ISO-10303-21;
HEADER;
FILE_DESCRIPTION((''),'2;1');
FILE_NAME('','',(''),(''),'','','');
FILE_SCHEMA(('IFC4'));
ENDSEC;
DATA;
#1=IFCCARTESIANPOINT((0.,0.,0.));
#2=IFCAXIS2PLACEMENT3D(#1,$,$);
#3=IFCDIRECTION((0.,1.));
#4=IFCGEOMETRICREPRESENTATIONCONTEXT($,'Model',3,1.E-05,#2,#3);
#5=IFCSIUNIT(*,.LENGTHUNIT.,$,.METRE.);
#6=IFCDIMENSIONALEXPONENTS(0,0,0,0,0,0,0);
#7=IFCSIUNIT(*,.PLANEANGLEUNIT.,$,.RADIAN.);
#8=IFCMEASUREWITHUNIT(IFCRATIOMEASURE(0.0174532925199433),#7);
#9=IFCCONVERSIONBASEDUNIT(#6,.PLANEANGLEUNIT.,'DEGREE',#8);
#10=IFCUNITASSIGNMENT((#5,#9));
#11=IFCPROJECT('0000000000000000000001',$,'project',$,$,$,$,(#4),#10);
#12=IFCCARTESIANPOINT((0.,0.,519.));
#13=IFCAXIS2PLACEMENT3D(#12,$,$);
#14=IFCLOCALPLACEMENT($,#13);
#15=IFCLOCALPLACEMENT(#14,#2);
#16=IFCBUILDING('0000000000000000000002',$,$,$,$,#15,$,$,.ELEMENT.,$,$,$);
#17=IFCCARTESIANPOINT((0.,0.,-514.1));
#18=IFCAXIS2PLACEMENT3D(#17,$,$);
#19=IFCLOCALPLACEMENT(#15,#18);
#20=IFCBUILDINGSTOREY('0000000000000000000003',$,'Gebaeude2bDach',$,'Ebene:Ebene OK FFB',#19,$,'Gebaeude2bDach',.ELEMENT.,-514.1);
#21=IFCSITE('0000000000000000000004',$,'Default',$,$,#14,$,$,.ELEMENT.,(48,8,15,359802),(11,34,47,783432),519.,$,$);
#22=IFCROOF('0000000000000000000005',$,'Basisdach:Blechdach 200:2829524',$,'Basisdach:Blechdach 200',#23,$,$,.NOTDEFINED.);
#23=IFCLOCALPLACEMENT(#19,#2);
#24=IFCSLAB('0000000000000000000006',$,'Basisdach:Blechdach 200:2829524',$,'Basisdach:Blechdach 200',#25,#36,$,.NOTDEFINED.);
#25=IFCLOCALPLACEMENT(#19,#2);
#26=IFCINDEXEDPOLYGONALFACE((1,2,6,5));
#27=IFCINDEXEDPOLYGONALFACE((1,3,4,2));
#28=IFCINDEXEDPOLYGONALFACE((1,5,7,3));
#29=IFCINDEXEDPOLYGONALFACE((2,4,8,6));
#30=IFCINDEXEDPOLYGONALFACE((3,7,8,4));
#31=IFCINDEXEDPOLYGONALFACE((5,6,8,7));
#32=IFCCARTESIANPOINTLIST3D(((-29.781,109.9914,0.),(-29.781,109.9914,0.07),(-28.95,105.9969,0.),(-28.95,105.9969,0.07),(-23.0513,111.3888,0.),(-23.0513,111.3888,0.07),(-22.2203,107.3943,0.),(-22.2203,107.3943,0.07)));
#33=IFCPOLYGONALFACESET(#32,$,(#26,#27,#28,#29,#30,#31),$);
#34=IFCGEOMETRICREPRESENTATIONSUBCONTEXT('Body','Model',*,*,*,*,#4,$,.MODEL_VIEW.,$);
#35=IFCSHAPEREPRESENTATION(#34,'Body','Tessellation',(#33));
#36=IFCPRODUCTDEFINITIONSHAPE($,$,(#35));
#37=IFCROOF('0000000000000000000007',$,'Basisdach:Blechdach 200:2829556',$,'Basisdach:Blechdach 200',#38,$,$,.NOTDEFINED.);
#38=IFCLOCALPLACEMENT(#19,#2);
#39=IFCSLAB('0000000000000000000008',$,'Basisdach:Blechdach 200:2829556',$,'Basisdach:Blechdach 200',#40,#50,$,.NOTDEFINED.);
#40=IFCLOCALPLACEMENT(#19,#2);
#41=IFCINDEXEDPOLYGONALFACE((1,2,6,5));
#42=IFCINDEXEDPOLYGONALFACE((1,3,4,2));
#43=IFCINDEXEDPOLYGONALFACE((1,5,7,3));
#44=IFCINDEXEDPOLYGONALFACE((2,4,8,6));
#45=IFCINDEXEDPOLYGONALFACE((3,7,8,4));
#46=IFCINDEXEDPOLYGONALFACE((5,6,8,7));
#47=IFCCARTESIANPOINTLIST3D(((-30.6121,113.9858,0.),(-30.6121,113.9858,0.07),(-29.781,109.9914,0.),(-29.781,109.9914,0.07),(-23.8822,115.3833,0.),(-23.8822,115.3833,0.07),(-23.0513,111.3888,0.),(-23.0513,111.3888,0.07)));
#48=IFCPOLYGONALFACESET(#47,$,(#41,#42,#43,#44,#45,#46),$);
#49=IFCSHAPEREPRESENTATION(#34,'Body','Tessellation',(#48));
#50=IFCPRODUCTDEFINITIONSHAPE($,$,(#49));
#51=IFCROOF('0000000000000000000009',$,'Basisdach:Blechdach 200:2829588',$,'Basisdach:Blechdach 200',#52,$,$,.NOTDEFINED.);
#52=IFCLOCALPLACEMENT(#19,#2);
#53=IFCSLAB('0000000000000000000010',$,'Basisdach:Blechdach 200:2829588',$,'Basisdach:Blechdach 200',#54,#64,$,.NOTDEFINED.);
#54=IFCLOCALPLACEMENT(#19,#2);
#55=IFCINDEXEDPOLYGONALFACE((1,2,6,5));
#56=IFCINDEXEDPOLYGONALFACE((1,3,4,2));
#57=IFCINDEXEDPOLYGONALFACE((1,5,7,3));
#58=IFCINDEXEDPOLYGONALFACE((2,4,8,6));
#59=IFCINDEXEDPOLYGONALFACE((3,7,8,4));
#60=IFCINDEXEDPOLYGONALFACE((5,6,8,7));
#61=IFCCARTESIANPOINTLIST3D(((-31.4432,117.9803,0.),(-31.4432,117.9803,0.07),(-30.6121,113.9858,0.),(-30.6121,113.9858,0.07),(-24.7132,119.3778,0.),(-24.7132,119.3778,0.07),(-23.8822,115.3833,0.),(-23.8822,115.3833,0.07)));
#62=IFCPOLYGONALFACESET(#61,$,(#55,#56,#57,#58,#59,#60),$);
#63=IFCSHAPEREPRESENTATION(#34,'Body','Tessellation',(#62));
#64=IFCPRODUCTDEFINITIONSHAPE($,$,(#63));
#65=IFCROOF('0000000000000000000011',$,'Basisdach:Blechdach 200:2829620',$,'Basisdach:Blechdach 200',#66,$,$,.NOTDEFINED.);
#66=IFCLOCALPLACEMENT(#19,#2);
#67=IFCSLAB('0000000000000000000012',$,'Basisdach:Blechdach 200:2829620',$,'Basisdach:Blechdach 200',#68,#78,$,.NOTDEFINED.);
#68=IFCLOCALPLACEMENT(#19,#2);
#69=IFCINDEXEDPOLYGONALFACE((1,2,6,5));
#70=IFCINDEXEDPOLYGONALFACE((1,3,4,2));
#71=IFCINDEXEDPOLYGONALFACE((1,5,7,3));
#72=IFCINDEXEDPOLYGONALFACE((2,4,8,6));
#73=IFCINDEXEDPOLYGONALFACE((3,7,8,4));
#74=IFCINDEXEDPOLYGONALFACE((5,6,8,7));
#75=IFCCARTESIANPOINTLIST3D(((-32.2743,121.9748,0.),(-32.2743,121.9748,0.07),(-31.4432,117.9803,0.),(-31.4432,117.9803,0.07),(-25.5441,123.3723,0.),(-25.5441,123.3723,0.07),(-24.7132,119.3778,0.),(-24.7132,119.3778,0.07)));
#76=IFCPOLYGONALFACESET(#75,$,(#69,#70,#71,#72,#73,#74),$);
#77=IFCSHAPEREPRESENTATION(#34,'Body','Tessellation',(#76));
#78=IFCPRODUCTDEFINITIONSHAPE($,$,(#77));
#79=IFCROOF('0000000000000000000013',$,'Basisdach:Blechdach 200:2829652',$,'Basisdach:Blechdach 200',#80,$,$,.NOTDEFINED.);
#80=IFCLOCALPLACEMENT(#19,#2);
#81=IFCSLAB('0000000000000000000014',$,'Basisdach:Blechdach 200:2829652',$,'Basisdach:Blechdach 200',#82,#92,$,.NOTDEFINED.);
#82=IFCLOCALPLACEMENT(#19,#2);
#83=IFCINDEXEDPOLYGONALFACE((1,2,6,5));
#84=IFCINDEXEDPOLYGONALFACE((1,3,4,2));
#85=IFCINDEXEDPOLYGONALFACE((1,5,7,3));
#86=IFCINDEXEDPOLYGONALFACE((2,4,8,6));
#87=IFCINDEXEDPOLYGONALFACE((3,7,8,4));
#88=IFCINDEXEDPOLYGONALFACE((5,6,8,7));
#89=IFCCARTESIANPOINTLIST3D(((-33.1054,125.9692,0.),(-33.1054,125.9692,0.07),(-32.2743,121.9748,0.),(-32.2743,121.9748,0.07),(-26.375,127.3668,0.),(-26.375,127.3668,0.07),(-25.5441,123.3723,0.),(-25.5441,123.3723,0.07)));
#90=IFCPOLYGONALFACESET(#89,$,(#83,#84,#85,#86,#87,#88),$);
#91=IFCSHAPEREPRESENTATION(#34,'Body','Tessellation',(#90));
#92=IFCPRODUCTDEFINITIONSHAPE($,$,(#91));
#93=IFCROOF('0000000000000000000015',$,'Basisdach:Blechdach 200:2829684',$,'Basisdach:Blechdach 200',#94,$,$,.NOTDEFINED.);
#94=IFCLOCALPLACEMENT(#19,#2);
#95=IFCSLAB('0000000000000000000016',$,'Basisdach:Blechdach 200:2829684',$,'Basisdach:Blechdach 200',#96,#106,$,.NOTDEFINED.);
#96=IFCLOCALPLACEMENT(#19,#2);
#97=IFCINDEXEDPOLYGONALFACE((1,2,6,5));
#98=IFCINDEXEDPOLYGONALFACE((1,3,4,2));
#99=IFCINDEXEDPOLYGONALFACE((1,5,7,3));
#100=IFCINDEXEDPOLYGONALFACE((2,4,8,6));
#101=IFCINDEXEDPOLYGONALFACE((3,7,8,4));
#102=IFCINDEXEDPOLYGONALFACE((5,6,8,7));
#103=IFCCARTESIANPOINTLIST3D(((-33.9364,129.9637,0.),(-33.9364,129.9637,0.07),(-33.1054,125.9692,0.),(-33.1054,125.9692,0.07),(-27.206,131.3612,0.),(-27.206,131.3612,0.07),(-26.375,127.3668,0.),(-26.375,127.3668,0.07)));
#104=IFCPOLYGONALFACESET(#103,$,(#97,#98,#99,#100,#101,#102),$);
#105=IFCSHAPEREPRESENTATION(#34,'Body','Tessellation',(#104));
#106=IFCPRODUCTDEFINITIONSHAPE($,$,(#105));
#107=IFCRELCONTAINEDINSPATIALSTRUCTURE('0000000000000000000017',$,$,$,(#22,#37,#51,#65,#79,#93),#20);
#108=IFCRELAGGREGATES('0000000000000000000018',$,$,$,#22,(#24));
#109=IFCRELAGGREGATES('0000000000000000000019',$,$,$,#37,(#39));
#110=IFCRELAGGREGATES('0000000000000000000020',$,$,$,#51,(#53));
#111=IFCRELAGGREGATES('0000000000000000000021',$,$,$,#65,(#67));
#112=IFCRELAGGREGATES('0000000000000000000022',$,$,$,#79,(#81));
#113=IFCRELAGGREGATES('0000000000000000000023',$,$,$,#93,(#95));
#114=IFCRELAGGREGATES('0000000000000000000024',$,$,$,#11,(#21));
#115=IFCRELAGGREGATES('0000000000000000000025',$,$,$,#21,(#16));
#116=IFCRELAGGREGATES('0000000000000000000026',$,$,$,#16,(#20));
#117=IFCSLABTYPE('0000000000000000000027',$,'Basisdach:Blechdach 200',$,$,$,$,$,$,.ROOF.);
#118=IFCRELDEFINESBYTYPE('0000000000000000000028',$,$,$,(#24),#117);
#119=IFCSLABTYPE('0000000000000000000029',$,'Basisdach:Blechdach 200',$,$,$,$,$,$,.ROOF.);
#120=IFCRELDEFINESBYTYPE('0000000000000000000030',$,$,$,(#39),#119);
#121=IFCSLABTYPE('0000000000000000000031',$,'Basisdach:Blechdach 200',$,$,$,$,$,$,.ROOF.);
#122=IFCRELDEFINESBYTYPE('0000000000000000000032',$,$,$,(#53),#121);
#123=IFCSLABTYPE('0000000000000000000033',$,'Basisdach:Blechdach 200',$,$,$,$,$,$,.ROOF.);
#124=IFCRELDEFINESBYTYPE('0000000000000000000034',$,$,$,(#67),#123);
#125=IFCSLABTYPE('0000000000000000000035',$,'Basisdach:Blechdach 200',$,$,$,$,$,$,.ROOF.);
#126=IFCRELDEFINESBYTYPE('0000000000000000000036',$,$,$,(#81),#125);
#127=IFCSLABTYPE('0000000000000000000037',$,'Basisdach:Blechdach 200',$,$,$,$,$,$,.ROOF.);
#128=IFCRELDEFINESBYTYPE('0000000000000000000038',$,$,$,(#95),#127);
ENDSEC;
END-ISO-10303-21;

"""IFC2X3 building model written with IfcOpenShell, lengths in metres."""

from ifc_helpers import new_model, entity, si_unit, converted_unit, direction, frame, origin, place, context, subcontext, project, spatial, polyline, outline, extrude, type_object, element, aggregate, save


model = new_model("IFC2X3")

# Units and contexts
model_context = context("Model", 3, precision=1e-05, world=origin(), true_north=direction((0.0, 1.0)))
body_context = subcontext(model_context, "Body", "Model", "MODEL_VIEW")
ifc_project = project(units=[si_unit("LENGTHUNIT", "METRE"), converted_unit("PLANEANGLEUNIT", "DEGREE", entity("IfcRatioMeasure", 0.0174532925199433), si_unit("PLANEANGLEUNIT", "RADIAN"), dimensions=[0, 0, 0, 0, 0, 0, 0])], contexts=[model_context])

# Site, building, storey
site_placement = place(None, frame((0.0, 0.0, 519.0)))
site = spatial("IfcSite", under=ifc_project, at=site_placement, Name="Default", CompositionType="ELEMENT", RefLatitude=(48, 8, 15, 359802), RefLongitude=(11, 34, 47, 783432), RefElevation=519.0)
building_placement = place(site_placement, origin())
building = spatial("IfcBuilding", under=site, at=building_placement, CompositionType="ELEMENT")
storey_placement = place(building_placement, frame((0.0, 0.0, -514.1)))
storey = spatial("IfcBuildingStorey", under=building, at=storey_placement, Name="Gebaeude2bDach", ObjectType="Ebene:Ebene OK FFB", LongName="Gebaeude2bDach", CompositionType="ELEMENT", Elevation=-514.1)

# Roofs, slabs
roof_1_placement = place(storey_placement, frame((-29.781, 105.9969, 0.0)))
roof_1 = element("IfcRoof", 1, at=roof_1_placement, inside=storey, Name="Basisdach:Blechdach 200:2829524", ObjectType="Basisdach:Blechdach 200", ShapeType="NOTDEFINED")
slab_type_1 = type_object("IfcSlabType", Name="Basisdach:Blechdach 200", PredefinedType="ROOF")
slab_1_placement = place(roof_1_placement, origin())
slab_1 = element("IfcSlab", 2, at=slab_1_placement, type_object=slab_type_1, Name="Basisdach:Blechdach 200:2829524", ObjectType="Basisdach:Blechdach 200", PredefinedType="NOTDEFINED", context=body_context, shape_type="SweptSolid", body=[
    extrude(outline(polyline([(3.7803, -1.2985), (2.9494, 2.6959), (-3.7803, 1.2985), (-2.9493, -2.6959), (3.7803, -1.2985)])), frame((3.7803, 2.6959, 0.0)), (0.0, 0.0, 1.0), 0.07),
])
aggregate(roof_1, [slab_1])
roof_2_placement = place(storey_placement, frame((-30.6121, 109.9914, 0.0)))
roof_2 = element("IfcRoof", 3, at=roof_2_placement, inside=storey, Name="Basisdach:Blechdach 200:2829556", ObjectType="Basisdach:Blechdach 200", ShapeType="NOTDEFINED")
slab_type_2 = type_object("IfcSlabType", Name="Basisdach:Blechdach 200", PredefinedType="ROOF")
slab_2_placement = place(roof_2_placement, origin())
slab_2 = element("IfcSlab", 4, at=slab_2_placement, type_object=slab_type_2, Name="Basisdach:Blechdach 200:2829556", ObjectType="Basisdach:Blechdach 200", PredefinedType="NOTDEFINED", context=body_context, shape_type="SweptSolid", body=[
    extrude(outline(polyline([(3.7804, -1.2985), (2.9495, 2.696), (-3.7804, 1.2985), (-2.9493, -2.696), (3.7804, -1.2985)])), frame((3.7804, 2.696, 0.0)), (0.0, 0.0, 1.0), 0.07),
])
aggregate(roof_2, [slab_2])
roof_3_placement = place(storey_placement, frame((-31.4432, 113.9858, 0.0)))
roof_3 = element("IfcRoof", 5, at=roof_3_placement, inside=storey, Name="Basisdach:Blechdach 200:2829588", ObjectType="Basisdach:Blechdach 200", ShapeType="NOTDEFINED")
slab_type_3 = type_object("IfcSlabType", Name="Basisdach:Blechdach 200", PredefinedType="ROOF")
slab_3_placement = place(roof_3_placement, origin())
slab_3 = element("IfcSlab", 6, at=slab_3_placement, type_object=slab_type_3, Name="Basisdach:Blechdach 200:2829588", ObjectType="Basisdach:Blechdach 200", PredefinedType="NOTDEFINED", context=body_context, shape_type="SweptSolid", body=[
    extrude(outline(polyline([(3.7805, -1.2985), (2.9495, 2.696), (-3.7805, 1.2985), (-2.9494, -2.696), (3.7805, -1.2985)])), frame((3.7805, 2.696, 0.0)), (0.0, 0.0, 1.0), 0.07),
])
aggregate(roof_3, [slab_3])
roof_4_placement = place(storey_placement, frame((-32.2743, 117.9803, 0.0)))
roof_4 = element("IfcRoof", 7, at=roof_4_placement, inside=storey, Name="Basisdach:Blechdach 200:2829620", ObjectType="Basisdach:Blechdach 200", ShapeType="NOTDEFINED")
slab_type_4 = type_object("IfcSlabType", Name="Basisdach:Blechdach 200", PredefinedType="ROOF")
slab_4_placement = place(roof_4_placement, origin())
slab_4 = element("IfcSlab", 8, at=slab_4_placement, type_object=slab_type_4, Name="Basisdach:Blechdach 200:2829620", ObjectType="Basisdach:Blechdach 200", PredefinedType="NOTDEFINED", context=body_context, shape_type="SweptSolid", body=[
    extrude(outline(polyline([(3.7806, -1.2985), (2.9496, 2.696), (-3.7806, 1.2985), (-2.9495, -2.696), (3.7806, -1.2985)])), frame((3.7806, 2.696, 0.0)), (0.0, 0.0, 1.0), 0.07),
])
aggregate(roof_4, [slab_4])
roof_5_placement = place(storey_placement, frame((-33.1054, 121.9748, 0.0)))
roof_5 = element("IfcRoof", 9, at=roof_5_placement, inside=storey, Name="Basisdach:Blechdach 200:2829652", ObjectType="Basisdach:Blechdach 200", ShapeType="NOTDEFINED")
slab_type_5 = type_object("IfcSlabType", Name="Basisdach:Blechdach 200", PredefinedType="ROOF")
slab_5_placement = place(roof_5_placement, origin())
slab_5 = element("IfcSlab", 10, at=slab_5_placement, type_object=slab_type_5, Name="Basisdach:Blechdach 200:2829652", ObjectType="Basisdach:Blechdach 200", PredefinedType="NOTDEFINED", context=body_context, shape_type="SweptSolid", body=[
    extrude(outline(polyline([(-3.7806, 1.2985), (-2.9495, -2.696), (3.7806, -1.2985), (2.9497, 2.696), (-3.7806, 1.2985)])), frame((3.7806, 2.696, 0.0)), (0.0, 0.0, 1.0), 0.07),
])
aggregate(roof_5, [slab_5])
roof_6_placement = place(storey_placement, frame((-33.9364, 125.9692, 0.0)))
roof_6 = element("IfcRoof", 11, at=roof_6_placement, inside=storey, Name="Basisdach:Blechdach 200:2829684", ObjectType="Basisdach:Blechdach 200", ShapeType="NOTDEFINED")
slab_type_6 = type_object("IfcSlabType", Name="Basisdach:Blechdach 200", PredefinedType="ROOF")
slab_6_placement = place(roof_6_placement, origin())
slab_6 = element("IfcSlab", 12, at=slab_6_placement, type_object=slab_type_6, Name="Basisdach:Blechdach 200:2829684", ObjectType="Basisdach:Blechdach 200", PredefinedType="NOTDEFINED", context=body_context, shape_type="SweptSolid", body=[
    extrude(outline(polyline([(-3.7807, 1.2984), (-2.9496, -2.696), (3.7807, -1.2985), (2.9498, 2.696), (-3.7807, 1.2984)])), frame((3.7807, 2.696, 0.0)), (0.0, 0.0, 1.0), 0.07),
])
aggregate(roof_6, [slab_6])

save(model, "model.ifc")
